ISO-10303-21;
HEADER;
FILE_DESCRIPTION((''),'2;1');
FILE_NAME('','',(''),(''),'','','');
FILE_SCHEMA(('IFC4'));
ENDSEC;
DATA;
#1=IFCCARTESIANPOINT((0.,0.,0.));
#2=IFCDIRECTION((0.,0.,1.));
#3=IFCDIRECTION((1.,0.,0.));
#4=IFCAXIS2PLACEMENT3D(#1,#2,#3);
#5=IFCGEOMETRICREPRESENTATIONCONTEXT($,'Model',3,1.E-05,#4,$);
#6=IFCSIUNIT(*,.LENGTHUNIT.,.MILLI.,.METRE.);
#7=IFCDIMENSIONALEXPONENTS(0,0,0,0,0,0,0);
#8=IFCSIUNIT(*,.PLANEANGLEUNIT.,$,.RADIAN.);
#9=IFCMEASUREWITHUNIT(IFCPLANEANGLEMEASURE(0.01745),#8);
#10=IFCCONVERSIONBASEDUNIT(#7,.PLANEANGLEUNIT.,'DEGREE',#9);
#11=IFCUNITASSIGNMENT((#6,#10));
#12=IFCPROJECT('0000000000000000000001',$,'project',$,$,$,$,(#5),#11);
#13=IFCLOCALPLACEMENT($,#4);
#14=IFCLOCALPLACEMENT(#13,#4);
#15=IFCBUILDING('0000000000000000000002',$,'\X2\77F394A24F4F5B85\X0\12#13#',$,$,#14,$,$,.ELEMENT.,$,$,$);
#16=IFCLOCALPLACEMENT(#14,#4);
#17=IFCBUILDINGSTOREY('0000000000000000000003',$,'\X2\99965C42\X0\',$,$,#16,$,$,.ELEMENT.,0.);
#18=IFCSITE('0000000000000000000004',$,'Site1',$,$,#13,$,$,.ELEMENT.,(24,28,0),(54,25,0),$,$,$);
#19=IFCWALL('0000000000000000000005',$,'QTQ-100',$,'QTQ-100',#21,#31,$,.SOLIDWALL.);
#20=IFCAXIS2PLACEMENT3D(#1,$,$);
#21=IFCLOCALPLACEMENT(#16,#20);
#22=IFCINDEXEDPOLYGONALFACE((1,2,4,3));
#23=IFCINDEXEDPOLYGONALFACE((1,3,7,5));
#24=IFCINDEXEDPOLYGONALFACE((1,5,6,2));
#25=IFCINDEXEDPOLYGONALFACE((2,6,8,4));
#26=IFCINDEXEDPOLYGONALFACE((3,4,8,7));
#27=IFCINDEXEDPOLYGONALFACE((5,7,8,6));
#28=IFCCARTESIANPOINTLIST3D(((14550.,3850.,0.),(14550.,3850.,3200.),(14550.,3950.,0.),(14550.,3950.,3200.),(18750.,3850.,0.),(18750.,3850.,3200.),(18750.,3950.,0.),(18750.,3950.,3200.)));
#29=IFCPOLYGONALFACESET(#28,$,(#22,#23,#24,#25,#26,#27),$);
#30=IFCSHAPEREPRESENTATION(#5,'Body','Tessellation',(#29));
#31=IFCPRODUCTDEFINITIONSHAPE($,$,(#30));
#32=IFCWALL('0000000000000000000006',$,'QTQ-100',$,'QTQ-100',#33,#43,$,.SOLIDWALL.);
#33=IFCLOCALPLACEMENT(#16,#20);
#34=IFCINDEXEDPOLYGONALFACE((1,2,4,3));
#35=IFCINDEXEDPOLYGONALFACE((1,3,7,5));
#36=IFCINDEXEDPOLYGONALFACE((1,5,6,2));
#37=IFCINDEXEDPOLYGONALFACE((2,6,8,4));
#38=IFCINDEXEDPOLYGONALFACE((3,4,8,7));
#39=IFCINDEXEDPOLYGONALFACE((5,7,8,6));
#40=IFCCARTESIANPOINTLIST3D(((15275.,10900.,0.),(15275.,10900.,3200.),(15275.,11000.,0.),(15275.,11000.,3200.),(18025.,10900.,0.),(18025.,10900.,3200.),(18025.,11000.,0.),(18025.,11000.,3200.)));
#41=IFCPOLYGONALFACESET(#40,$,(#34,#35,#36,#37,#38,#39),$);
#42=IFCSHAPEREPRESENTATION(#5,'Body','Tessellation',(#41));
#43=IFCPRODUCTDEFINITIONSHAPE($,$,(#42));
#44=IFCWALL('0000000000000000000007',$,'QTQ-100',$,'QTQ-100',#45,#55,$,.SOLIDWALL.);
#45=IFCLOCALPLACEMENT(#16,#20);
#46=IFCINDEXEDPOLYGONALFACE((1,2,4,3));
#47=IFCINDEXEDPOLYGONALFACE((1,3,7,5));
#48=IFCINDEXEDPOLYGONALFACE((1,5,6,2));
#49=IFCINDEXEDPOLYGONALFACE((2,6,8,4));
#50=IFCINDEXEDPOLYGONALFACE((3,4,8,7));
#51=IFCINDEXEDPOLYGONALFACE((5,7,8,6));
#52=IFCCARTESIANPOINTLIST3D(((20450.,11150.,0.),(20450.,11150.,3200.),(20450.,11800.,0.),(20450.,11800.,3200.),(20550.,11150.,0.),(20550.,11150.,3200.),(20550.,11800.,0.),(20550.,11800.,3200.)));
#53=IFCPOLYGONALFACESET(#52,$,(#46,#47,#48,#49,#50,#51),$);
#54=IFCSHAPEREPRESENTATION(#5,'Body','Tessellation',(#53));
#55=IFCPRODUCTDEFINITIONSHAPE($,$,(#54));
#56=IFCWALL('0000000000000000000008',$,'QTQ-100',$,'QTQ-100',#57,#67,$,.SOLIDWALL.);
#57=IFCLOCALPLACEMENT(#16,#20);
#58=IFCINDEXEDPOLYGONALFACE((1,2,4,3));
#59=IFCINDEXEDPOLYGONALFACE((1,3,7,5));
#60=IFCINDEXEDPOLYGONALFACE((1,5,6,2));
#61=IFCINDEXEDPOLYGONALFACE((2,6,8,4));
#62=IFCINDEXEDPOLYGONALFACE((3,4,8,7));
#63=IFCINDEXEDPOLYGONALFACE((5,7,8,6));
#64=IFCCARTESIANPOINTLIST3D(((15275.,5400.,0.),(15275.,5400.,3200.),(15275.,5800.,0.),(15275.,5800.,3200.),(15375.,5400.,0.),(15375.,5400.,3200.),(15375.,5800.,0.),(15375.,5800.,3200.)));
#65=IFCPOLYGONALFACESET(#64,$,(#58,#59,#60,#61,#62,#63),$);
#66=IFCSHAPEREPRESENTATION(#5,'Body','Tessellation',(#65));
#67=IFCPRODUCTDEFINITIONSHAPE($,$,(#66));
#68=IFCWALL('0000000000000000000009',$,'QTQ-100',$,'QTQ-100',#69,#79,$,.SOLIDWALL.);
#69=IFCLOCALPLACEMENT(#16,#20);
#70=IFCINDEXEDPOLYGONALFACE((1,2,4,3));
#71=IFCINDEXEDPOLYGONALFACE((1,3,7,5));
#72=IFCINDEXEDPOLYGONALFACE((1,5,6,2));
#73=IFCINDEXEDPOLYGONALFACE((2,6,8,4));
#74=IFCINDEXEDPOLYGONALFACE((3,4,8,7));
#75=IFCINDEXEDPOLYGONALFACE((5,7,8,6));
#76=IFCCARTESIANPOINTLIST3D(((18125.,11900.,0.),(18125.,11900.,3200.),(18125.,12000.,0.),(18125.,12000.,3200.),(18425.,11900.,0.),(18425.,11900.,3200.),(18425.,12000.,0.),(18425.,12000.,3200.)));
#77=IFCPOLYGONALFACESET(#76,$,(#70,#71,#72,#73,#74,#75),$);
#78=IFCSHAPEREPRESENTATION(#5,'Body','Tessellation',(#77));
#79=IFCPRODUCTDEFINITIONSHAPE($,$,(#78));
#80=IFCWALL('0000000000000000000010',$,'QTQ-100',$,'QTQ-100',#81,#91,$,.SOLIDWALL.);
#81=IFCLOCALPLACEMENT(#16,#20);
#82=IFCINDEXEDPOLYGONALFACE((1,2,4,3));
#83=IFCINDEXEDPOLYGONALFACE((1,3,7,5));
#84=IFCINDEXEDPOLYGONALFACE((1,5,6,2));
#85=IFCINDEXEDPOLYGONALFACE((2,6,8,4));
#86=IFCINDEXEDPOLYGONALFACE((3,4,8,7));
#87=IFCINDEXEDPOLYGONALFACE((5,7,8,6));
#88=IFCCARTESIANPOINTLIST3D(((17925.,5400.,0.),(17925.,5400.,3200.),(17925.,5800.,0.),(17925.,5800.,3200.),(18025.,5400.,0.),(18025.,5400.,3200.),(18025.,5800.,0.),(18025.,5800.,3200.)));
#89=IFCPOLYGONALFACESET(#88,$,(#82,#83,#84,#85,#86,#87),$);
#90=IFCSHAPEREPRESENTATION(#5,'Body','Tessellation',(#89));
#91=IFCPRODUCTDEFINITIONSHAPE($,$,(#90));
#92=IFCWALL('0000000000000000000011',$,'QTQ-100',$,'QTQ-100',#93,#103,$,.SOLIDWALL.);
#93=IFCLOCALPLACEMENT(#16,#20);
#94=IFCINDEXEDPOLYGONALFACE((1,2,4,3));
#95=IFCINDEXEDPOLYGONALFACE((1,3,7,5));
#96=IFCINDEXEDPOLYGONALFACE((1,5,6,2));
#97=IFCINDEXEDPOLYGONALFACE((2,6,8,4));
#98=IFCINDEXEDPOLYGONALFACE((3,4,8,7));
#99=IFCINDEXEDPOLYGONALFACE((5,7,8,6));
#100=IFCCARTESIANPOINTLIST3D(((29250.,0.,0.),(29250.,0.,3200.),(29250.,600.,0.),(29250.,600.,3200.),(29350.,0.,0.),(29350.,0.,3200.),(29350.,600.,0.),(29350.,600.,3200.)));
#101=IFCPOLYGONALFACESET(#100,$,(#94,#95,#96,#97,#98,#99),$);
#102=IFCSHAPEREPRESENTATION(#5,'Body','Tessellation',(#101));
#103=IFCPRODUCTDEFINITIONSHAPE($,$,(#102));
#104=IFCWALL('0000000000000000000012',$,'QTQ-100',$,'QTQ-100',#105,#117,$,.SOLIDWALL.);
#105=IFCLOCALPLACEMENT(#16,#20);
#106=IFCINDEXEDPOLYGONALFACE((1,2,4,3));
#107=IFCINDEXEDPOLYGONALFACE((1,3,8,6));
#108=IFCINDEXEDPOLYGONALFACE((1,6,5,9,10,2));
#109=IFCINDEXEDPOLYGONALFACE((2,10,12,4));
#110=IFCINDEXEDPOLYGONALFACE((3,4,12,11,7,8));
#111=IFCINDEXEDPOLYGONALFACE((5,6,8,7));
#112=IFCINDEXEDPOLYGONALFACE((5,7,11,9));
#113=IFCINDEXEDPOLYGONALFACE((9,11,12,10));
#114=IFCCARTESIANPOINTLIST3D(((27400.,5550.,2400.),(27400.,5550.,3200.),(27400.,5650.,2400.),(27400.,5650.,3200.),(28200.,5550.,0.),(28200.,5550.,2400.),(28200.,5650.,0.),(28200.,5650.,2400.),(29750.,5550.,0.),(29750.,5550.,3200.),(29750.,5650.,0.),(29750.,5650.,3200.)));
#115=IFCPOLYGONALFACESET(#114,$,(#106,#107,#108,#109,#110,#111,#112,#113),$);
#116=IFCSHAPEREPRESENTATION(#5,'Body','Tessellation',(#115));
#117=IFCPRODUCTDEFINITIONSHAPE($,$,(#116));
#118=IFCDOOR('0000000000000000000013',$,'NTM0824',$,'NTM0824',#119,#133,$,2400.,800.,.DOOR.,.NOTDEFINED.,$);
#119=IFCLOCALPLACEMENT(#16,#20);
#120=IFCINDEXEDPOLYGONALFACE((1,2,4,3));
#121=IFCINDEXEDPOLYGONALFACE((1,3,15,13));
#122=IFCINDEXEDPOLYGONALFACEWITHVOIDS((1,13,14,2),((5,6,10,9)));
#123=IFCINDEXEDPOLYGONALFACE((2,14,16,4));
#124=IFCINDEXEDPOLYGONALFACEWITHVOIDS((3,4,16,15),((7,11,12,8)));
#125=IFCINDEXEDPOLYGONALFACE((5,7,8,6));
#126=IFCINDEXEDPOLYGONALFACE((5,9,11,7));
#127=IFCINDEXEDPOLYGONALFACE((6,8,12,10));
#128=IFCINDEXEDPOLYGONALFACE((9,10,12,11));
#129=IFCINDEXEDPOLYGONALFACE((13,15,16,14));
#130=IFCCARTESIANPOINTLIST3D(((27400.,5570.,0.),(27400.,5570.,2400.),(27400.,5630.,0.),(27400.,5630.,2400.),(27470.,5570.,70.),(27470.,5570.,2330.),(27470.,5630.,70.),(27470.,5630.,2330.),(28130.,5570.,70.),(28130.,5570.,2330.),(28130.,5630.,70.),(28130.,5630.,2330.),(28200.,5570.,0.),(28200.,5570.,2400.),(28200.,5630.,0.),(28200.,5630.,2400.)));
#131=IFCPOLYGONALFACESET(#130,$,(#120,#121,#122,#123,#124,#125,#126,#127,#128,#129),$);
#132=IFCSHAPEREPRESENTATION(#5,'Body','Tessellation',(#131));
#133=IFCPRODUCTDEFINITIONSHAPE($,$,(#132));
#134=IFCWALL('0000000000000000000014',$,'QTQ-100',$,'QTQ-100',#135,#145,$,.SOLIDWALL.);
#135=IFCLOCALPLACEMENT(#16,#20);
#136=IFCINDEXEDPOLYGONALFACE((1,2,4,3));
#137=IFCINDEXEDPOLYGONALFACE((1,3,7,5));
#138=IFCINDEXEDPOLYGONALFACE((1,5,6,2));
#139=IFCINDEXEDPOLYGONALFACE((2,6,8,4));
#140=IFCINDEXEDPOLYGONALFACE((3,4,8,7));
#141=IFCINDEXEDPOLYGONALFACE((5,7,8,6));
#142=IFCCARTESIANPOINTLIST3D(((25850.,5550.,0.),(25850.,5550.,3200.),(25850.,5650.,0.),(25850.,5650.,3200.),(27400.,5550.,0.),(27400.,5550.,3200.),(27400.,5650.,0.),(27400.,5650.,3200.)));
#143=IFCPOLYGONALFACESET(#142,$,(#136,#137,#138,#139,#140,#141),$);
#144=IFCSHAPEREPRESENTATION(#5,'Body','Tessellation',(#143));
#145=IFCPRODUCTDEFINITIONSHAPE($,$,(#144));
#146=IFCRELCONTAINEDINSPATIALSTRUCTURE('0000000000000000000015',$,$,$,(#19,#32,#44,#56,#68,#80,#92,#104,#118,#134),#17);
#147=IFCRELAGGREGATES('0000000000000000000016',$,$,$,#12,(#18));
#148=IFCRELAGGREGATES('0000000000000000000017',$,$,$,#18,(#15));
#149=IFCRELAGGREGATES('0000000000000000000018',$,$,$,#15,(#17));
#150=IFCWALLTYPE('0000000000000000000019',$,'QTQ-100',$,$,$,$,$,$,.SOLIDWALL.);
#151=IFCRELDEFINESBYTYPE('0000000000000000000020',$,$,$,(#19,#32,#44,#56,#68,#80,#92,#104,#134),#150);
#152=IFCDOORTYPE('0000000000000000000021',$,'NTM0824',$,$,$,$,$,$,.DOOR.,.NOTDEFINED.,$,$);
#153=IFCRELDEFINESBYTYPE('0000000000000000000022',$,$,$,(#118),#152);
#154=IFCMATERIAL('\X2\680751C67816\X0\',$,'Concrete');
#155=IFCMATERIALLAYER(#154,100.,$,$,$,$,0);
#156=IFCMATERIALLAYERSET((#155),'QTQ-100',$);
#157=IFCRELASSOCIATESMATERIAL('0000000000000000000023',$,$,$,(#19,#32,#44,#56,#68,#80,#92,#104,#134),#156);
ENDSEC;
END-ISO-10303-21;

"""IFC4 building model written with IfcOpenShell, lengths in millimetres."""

from ifc_helpers import new_model, entity, si_unit, converted_unit, frame, origin_with_axes, place, context, project, spatial, polyline, outline, extrude, material, layer, layer_set, type_object, element, fill, save


model = new_model("IFC4")

# Units and contexts
model_context = context("Model", 3, precision=1e-05, world=origin_with_axes())
ifc_project = project(units=[si_unit("LENGTHUNIT", "METRE", prefix="MILLI"), converted_unit("PLANEANGLEUNIT", "DEGREE", entity("IfcPlaneAngleMeasure", 0.01745), si_unit("PLANEANGLEUNIT", "RADIAN"), dimensions=[0, 0, 0, 0, 0, 0, 0])], contexts=[model_context])

# Site, building, storey
site_placement = place(None, origin_with_axes())
site = spatial("IfcSite", under=ifc_project, at=site_placement, Name="Site1", CompositionType="ELEMENT", RefLatitude=(24, 28, 0), RefLongitude=(54, 25, 0))
building_placement = place(site_placement, origin_with_axes())
building = spatial("IfcBuilding", under=site, at=building_placement, Name="石钢住宅12#13#", CompositionType="ELEMENT")
storey_placement = place(building_placement, origin_with_axes())
storey = spatial("IfcBuildingStorey", under=building, at=storey_placement, Name="首层", CompositionType="ELEMENT", Elevation=0.0)

# Walls
ifc_material_1 = material(Name="标准砖", Category="Concrete")
ifc_layer_1 = layer(ifc_material_1, 100.0, Priority=0)
ifc_layer_set_1 = layer_set([ifc_layer_1], Name="QTQ-100")
wall_type_1 = type_object("IfcWallType", Name="QTQ-100", PredefinedType="SOLIDWALL")
wall_1_placement = place(storey_placement, origin_with_axes())
element("IfcWall", 1, at=wall_1_placement, inside=storey, type_object=wall_type_1, material=ifc_layer_set_1, Name="QTQ-100", ObjectType="QTQ-100", PredefinedType="SOLIDWALL", context=model_context, shape_type="SweptSolid", body=[
    extrude(outline(polyline([(0.0, 0.0), (3200.0, 0.0), (3200.0, 4200.0), (0.0, 4200.0), (0.0, 0.0)])), frame((14550.0, 3950.0, 3200.0), z_axis=(0.0, -1.0, 0.0), x_axis=(0.0, 0.0, -1.0)), (0.0, 0.0, 1.0), 100.0),
])
wall_2_placement = place(storey_placement, origin_with_axes())
element("IfcWall", 2, at=wall_2_placement, inside=storey, type_object=wall_type_1, material=ifc_layer_set_1, Name="QTQ-100", ObjectType="QTQ-100", PredefinedType="SOLIDWALL", context=model_context, shape_type="SweptSolid", body=[
    extrude(outline(polyline([(0.0, 0.0), (3200.0, 0.0), (3200.0, 2750.0), (0.0, 2750.0), (0.0, 0.0)])), frame((15275.0, 11000.0, 3200.0), z_axis=(0.0, -1.0, 0.0), x_axis=(0.0, 0.0, -1.0)), (0.0, 0.0, 1.0), 100.0),
])
wall_3_placement = place(storey_placement, origin_with_axes())
element("IfcWall", 3, at=wall_3_placement, inside=storey, type_object=wall_type_1, material=ifc_layer_set_1, Name="QTQ-100", ObjectType="QTQ-100", PredefinedType="SOLIDWALL", context=model_context, shape_type="SweptSolid", body=[
    extrude(outline(polyline([(0.0, 0.0), (3200.0, 0.0), (3200.0, 650.0), (0.0, 650.0), (0.0, 0.0)])), frame((20450.0, 11150.0, 3200.0), z_axis=(1.0, 0.0, 0.0), x_axis=(0.0, 0.0, -1.0)), (0.0, 0.0, 1.0), 100.0),
])
wall_4_placement = place(storey_placement, origin_with_axes())
element("IfcWall", 4, at=wall_4_placement, inside=storey, type_object=wall_type_1, material=ifc_layer_set_1, Name="QTQ-100", ObjectType="QTQ-100", PredefinedType="SOLIDWALL", context=model_context, shape_type="SweptSolid", body=[
    extrude(outline(polyline([(0.0, 0.0), (3200.0, 0.0), (3200.0, 400.0), (0.0, 400.0), (0.0, 0.0)])), frame((15375.0, 5800.0, 3200.0), z_axis=(-1.0, 0.0, 0.0), x_axis=(0.0, 0.0, -1.0)), (0.0, 0.0, 1.0), 100.0),
])
wall_5_placement = place(storey_placement, origin_with_axes())
element("IfcWall", 5, at=wall_5_placement, inside=storey, type_object=wall_type_1, material=ifc_layer_set_1, Name="QTQ-100", ObjectType="QTQ-100", PredefinedType="SOLIDWALL", context=model_context, shape_type="SweptSolid", body=[
    extrude(outline(polyline([(0.0, 0.0), (3200.0, 0.0), (3200.0, 300.0), (0.0, 300.0), (0.0, 0.0)])), frame((18125.0, 12000.0, 3200.0), z_axis=(0.0, -1.0, 0.0), x_axis=(0.0, 0.0, -1.0)), (0.0, 0.0, 1.0), 100.0),
])
wall_6_placement = place(storey_placement, origin_with_axes())
element("IfcWall", 6, at=wall_6_placement, inside=storey, type_object=wall_type_1, material=ifc_layer_set_1, Name="QTQ-100", ObjectType="QTQ-100", PredefinedType="SOLIDWALL", context=model_context, shape_type="SweptSolid", body=[
    extrude(outline(polyline([(0.0, 0.0), (3200.0, 0.0), (3200.0, 400.0), (0.0, 400.0), (0.0, 0.0)])), frame((18025.0, 5800.0, 3200.0), z_axis=(-1.0, 0.0, 0.0), x_axis=(0.0, 0.0, -1.0)), (0.0, 0.0, 1.0), 100.0),
])
wall_7_placement = place(storey_placement, origin_with_axes())
element("IfcWall", 7, at=wall_7_placement, inside=storey, type_object=wall_type_1, material=ifc_layer_set_1, Name="QTQ-100", ObjectType="QTQ-100", PredefinedType="SOLIDWALL", context=model_context, shape_type="SweptSolid", body=[
    extrude(outline(polyline([(0.0, 0.0), (3200.0, 0.0), (3200.0, 600.0), (0.0, 600.0), (0.0, 0.0)])), frame((29250.0, 0.0, 3200.0), z_axis=(1.0, 0.0, 0.0), x_axis=(0.0, 0.0, -1.0)), (0.0, 0.0, 1.0), 100.0),
])

# Wall, opening, door
wall_8_placement = place(storey_placement, origin_with_axes())
wall_8 = element("IfcWall", 8, at=wall_8_placement, inside=storey, type_object=wall_type_1, material=ifc_layer_set_1, Name="QTQ-100", ObjectType="QTQ-100", PredefinedType="SOLIDWALL", context=model_context, shape_type="SweptSolid", body=[
    extrude(outline(polyline([(0.0, 0.0), (3200.0, 0.0), (3200.0, 2350.0), (0.0, 2350.0), (0.0, 0.0)])), frame((27400.0, 5650.0, 3200.0), z_axis=(0.0, -1.0, 0.0), x_axis=(0.0, 0.0, -1.0)), (0.0, 0.0, 1.0), 100.0),
])
opening_1_placement = place(storey_placement, origin_with_axes())
opening_1 = element("IfcOpeningElement", 9, at=opening_1_placement, cuts=wall_8, PredefinedType="OPENING", context=model_context, shape_type="SweptSolid", body=[
    extrude(outline(polyline([(0.0, 0.0), (800.0, 0.0), (800.0, 2400.0), (0.0, 2400.0), (0.0, 0.0)])), frame((27400.0, 6650.0, 0.0), z_axis=(0.0, -1.0, 0.0), x_axis=(1.0, 0.0, 0.0)), (0.0, 0.0, 1.0), 2100.0),
])
door_type_1 = type_object("IfcDoorType", Name="NTM0824", OperationType="NOTDEFINED", PredefinedType="DOOR")
door_1_placement = place(storey_placement, origin_with_axes())
door_1 = element("IfcDoor", 10, at=door_1_placement, inside=storey, type_object=door_type_1, Name="NTM0824", ObjectType="NTM0824", OperationType="NOTDEFINED", OverallHeight=2400.0, OverallWidth=800.0, PredefinedType="DOOR", context=model_context, shape_type="SweptSolid", body=[
    extrude(outline(polyline([(-400.0, -1200.0), (400.0, -1200.0), (400.0, 1200.0), (-400.0, 1200.0), (-400.0, -1200.0)]), holes=[polyline([(-330.0, -1130.0), (-330.0, 1130.0), (330.0, 1130.0), (330.0, -1130.0), (-330.0, -1130.0)])]), frame((27800.0, 5630.0, 1200.0), z_axis=(0.0, -1.0, 0.0), x_axis=(1.0, 0.0, 0.0)), (0.0, 0.0, 1.0), 60.0),
])
fill(opening_1, door_1)

# Wall
wall_9_placement = place(storey_placement, origin_with_axes())
element("IfcWall", 11, at=wall_9_placement, inside=storey, type_object=wall_type_1, material=ifc_layer_set_1, Name="QTQ-100", ObjectType="QTQ-100", PredefinedType="SOLIDWALL", context=model_context, shape_type="SweptSolid", body=[
    extrude(outline(polyline([(0.0, 0.0), (3200.0, 0.0), (3200.0, 1550.0), (0.0, 1550.0), (0.0, 0.0)])), frame((25850.0, 5650.0, 3200.0), z_axis=(0.0, -1.0, 0.0), x_axis=(0.0, 0.0, -1.0)), (0.0, 0.0, 1.0), 100.0),
])

save(model, "model.ifc")
